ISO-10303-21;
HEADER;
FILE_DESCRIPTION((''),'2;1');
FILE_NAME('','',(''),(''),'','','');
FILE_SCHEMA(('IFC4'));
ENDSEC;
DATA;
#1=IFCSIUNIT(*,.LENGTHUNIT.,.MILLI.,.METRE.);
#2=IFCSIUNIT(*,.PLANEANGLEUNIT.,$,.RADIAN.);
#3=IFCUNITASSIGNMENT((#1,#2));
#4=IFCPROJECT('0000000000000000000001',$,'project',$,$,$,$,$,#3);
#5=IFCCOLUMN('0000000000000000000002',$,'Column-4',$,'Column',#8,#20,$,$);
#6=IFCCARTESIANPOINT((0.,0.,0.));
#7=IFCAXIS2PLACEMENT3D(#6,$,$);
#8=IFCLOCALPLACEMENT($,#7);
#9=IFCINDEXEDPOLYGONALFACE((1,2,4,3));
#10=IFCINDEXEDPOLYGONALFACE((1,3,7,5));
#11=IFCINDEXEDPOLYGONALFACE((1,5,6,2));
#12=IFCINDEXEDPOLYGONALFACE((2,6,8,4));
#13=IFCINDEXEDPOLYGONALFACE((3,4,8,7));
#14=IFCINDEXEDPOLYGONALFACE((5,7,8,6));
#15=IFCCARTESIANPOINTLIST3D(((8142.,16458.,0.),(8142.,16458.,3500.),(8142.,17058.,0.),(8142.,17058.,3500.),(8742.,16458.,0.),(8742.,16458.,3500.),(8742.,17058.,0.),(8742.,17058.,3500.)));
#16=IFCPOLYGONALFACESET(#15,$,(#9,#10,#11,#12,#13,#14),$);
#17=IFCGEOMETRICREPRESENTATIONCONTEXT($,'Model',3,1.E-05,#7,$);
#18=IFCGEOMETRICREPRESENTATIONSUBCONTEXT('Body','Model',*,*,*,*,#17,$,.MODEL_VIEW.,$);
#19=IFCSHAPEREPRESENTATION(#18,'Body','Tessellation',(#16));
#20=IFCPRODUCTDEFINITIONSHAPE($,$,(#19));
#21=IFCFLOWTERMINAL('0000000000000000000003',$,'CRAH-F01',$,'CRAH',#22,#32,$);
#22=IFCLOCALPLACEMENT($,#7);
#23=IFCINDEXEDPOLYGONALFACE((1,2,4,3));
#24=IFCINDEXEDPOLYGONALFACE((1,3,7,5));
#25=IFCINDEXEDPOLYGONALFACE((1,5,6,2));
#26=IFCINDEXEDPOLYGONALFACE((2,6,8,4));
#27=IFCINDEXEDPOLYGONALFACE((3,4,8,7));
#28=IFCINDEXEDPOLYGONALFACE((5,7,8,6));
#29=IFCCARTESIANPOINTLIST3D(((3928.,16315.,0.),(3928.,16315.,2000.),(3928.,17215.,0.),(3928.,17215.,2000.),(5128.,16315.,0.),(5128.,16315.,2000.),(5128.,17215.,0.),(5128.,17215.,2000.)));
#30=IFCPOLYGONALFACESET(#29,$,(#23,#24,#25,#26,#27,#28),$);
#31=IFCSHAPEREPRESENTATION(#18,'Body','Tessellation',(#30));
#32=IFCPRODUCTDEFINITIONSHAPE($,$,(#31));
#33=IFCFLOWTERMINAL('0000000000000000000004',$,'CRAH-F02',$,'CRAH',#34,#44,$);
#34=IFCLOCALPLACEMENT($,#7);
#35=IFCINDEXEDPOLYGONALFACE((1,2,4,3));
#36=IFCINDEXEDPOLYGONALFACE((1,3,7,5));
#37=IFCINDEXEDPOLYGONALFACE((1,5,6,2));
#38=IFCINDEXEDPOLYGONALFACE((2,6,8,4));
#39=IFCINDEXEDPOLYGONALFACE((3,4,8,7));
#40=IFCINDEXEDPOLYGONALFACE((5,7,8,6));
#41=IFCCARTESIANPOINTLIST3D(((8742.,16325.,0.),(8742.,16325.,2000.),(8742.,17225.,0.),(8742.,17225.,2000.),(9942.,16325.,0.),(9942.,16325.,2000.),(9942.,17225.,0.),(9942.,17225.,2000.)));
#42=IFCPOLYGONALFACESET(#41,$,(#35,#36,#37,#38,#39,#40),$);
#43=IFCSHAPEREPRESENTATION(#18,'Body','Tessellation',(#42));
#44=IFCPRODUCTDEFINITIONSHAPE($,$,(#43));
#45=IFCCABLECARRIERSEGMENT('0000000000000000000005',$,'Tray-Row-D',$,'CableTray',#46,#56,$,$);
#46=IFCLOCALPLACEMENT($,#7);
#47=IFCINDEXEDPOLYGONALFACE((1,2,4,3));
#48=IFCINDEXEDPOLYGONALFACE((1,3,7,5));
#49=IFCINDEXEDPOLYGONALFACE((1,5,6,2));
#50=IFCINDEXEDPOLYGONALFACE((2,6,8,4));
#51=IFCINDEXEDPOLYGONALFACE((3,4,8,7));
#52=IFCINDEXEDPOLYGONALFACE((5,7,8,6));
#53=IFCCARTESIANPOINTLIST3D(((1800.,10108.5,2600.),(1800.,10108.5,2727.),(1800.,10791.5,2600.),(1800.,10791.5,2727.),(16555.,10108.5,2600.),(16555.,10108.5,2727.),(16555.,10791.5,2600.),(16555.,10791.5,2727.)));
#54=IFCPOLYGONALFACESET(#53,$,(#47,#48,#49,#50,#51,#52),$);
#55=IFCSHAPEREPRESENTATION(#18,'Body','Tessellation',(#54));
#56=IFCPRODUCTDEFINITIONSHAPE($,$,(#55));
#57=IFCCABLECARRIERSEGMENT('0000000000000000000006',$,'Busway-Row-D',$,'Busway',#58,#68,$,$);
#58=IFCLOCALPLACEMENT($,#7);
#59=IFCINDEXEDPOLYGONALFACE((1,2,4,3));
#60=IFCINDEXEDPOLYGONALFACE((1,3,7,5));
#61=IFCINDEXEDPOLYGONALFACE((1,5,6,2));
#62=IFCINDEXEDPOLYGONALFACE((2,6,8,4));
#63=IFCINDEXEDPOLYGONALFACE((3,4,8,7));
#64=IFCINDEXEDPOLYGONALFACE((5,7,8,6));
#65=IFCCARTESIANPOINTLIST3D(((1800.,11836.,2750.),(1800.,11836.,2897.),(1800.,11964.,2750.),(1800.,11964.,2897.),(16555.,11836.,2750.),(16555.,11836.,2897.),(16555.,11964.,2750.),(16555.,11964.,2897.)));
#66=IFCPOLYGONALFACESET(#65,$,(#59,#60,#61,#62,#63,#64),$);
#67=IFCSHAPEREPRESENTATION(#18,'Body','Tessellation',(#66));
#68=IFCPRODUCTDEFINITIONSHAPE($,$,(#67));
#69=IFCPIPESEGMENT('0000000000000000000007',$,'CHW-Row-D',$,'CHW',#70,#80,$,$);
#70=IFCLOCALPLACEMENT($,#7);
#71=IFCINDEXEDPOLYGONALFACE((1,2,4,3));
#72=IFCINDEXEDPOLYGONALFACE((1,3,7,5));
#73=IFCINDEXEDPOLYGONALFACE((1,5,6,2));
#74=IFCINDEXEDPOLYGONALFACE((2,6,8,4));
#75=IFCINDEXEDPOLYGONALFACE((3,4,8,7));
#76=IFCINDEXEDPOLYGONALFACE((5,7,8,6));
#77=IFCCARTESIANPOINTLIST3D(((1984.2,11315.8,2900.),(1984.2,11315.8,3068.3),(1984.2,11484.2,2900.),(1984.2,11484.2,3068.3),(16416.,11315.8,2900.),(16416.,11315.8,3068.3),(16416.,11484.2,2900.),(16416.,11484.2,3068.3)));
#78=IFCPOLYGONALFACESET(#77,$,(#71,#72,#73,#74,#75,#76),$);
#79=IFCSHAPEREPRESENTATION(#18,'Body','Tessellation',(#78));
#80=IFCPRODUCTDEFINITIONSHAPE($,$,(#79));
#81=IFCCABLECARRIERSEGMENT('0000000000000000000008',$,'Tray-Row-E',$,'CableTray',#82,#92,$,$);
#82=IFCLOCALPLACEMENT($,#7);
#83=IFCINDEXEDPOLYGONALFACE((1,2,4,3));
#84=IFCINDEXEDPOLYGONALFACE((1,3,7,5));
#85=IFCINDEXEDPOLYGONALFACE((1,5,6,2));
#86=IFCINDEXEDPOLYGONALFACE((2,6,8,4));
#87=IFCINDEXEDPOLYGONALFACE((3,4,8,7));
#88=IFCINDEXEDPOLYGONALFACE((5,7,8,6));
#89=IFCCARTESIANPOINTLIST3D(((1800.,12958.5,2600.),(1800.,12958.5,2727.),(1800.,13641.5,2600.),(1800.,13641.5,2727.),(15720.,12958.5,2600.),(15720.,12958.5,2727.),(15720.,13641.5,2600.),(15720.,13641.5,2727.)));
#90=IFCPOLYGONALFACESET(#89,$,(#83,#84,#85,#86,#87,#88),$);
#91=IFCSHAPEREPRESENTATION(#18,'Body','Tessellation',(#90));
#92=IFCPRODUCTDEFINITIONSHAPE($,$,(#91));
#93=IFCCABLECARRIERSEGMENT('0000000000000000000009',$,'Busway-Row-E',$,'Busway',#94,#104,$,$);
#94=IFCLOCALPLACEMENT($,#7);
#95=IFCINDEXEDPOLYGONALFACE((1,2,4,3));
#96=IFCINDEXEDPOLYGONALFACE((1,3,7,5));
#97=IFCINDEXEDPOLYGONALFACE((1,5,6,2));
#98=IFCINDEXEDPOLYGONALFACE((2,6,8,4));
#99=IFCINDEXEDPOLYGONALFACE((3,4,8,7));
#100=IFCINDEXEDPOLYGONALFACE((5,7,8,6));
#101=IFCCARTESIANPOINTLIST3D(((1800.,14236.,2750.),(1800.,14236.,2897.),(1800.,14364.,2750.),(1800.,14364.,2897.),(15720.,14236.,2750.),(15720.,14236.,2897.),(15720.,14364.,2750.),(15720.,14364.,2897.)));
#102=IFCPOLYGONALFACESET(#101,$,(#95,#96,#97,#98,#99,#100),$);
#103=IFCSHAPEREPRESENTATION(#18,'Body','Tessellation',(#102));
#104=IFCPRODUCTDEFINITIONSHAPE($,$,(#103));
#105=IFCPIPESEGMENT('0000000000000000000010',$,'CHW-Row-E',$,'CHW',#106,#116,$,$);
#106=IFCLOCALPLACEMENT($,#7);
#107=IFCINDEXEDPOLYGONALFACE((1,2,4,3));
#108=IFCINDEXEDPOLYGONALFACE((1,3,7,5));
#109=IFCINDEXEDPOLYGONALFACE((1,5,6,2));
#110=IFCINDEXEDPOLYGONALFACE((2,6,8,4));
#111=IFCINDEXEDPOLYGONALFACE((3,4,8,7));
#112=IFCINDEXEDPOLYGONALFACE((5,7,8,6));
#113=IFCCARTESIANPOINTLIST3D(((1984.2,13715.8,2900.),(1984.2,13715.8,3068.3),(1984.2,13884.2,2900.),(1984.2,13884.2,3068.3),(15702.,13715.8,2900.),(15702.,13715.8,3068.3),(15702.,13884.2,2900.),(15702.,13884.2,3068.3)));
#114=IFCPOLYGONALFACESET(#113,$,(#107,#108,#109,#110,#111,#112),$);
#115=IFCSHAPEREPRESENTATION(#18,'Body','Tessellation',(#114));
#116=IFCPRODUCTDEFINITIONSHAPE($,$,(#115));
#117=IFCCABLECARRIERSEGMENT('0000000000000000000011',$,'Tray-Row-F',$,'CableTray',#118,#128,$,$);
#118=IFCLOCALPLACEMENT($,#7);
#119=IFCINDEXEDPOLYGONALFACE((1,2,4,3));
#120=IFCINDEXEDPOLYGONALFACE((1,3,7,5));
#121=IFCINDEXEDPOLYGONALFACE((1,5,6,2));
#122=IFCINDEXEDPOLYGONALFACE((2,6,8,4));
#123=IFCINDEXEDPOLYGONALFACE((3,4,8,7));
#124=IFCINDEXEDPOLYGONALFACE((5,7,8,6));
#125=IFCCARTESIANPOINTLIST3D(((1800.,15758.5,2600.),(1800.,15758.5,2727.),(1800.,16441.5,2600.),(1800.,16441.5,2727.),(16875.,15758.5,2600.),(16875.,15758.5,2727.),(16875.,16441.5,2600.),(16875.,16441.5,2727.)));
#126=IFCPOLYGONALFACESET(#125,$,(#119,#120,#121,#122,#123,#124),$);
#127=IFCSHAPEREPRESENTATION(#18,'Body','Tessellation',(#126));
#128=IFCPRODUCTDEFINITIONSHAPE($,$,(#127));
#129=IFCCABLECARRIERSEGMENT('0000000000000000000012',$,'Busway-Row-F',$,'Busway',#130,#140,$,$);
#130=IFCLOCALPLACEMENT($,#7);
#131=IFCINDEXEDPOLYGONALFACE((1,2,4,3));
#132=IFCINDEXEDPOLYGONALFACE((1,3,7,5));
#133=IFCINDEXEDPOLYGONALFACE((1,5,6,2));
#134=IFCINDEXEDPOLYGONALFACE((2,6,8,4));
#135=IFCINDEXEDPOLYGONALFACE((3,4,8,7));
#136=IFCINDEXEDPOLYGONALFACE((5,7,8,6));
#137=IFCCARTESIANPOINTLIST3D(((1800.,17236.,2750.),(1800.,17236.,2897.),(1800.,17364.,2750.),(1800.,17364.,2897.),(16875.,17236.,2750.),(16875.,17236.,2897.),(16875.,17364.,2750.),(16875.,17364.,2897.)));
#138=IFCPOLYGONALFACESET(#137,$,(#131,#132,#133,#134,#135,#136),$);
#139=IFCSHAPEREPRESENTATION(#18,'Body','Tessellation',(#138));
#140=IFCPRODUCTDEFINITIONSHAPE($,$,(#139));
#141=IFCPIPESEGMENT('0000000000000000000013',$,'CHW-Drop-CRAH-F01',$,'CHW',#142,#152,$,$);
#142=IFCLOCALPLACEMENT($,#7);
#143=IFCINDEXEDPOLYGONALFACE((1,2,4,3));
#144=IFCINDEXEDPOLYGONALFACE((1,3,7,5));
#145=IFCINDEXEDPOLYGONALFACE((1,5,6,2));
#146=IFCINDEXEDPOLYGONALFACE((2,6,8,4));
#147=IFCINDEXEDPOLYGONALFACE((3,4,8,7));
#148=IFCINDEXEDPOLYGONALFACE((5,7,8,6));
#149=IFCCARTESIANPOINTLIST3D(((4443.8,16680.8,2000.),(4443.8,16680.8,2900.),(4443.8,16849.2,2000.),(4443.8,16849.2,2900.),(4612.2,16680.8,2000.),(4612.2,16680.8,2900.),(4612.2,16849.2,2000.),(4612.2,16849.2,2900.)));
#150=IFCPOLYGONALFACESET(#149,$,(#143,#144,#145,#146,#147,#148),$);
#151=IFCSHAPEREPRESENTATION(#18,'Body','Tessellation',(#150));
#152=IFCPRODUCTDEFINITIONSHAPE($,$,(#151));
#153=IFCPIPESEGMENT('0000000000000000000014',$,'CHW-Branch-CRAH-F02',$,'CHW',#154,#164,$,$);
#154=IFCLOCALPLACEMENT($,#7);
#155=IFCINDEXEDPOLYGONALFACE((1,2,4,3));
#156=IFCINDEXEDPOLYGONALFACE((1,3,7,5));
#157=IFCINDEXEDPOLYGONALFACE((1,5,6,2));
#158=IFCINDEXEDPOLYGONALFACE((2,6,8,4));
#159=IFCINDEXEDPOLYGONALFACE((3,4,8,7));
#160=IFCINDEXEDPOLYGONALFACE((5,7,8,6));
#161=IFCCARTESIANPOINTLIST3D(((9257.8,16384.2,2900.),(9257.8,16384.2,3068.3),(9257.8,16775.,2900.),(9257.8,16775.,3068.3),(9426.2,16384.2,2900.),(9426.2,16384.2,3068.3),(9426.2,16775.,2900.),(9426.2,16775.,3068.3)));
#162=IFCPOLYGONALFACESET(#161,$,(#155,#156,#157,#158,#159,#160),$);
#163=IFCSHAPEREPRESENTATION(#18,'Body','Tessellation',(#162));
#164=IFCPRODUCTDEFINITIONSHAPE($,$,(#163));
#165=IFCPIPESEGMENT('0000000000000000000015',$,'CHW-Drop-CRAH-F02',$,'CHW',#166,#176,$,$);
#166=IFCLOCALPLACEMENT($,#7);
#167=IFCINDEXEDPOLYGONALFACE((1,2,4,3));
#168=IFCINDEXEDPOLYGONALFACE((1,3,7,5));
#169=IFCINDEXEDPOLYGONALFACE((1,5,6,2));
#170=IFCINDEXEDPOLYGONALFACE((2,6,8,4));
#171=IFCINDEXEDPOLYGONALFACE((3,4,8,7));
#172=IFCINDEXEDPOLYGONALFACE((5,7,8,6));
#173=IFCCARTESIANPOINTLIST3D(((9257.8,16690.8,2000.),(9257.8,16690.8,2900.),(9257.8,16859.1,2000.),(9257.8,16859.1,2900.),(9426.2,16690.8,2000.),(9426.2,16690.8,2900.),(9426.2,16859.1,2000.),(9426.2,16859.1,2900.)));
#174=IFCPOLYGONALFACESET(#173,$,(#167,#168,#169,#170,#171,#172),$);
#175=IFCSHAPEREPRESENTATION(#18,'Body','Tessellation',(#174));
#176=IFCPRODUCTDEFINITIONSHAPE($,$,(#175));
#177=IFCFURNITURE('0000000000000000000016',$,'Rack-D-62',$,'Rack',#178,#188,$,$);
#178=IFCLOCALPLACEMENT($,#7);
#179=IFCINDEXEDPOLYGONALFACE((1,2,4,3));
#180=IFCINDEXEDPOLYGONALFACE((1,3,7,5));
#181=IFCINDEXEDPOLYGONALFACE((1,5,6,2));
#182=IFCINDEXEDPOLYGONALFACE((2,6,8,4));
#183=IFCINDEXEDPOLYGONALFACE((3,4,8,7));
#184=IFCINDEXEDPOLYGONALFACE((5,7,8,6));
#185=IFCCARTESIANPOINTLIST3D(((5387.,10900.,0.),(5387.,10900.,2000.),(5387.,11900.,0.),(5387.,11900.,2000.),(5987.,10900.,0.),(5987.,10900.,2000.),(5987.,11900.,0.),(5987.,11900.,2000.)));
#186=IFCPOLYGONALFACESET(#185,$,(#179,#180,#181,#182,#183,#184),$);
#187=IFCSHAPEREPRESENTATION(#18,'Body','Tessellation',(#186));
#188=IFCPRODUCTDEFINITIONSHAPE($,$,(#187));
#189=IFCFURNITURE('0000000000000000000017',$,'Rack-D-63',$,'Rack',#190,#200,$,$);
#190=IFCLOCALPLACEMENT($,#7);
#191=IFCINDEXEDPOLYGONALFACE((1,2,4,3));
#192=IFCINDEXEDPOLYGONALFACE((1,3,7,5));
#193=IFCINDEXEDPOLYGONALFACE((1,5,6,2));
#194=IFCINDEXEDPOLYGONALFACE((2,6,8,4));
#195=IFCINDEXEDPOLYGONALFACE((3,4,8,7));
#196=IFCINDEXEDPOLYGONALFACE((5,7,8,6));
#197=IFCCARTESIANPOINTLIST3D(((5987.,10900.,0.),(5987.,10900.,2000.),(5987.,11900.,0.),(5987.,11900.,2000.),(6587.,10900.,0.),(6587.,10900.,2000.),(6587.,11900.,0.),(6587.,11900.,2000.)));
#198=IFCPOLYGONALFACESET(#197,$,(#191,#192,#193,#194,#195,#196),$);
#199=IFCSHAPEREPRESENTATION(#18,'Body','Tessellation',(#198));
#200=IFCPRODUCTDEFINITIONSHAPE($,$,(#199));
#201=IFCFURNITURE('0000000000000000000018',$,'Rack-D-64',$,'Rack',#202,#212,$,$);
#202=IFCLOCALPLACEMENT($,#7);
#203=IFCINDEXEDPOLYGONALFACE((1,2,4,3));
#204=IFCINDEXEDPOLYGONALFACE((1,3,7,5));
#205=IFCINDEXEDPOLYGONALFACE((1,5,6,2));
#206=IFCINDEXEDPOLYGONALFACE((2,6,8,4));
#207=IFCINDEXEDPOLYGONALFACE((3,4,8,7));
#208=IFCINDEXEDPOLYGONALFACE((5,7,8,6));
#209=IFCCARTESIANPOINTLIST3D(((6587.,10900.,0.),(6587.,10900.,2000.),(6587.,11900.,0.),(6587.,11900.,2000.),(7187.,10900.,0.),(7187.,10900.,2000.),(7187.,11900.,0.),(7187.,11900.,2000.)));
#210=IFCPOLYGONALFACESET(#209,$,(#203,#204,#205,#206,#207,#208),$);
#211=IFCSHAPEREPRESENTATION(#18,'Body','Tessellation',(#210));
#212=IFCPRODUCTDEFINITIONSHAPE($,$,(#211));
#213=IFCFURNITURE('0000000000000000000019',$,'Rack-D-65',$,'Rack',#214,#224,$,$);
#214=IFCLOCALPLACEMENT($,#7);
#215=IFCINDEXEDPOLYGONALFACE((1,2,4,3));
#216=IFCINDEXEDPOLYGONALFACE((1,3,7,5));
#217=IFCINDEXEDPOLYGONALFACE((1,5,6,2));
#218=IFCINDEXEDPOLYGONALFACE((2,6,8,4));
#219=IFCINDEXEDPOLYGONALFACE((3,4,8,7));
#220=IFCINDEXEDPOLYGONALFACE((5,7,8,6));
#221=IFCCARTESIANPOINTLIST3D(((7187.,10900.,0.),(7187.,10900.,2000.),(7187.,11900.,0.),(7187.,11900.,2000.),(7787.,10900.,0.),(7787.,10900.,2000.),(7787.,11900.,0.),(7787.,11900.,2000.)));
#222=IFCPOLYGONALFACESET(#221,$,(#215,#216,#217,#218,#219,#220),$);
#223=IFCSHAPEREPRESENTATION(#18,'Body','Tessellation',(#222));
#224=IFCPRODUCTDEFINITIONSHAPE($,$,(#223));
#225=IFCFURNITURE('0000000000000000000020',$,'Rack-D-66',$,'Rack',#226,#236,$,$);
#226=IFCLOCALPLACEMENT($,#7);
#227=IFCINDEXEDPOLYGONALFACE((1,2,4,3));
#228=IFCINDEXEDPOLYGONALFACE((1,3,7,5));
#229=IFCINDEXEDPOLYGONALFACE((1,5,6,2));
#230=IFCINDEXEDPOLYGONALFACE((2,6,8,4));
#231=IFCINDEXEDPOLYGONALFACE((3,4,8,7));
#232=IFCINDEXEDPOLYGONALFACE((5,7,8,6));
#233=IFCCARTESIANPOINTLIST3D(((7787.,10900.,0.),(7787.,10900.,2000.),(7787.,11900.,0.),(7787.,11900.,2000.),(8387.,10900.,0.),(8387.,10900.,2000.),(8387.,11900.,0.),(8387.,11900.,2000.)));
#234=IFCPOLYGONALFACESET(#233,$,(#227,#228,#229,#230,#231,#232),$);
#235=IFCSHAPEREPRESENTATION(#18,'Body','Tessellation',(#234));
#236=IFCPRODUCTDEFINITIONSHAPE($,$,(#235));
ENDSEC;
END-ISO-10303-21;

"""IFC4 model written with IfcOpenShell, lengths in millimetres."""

from ifc_helpers import new_model, si_unit, frame, origin, place, context, subcontext, project, rectangle, extrude, element, save


model = new_model("IFC4")

# Units and contexts
model_context = context("Model", 3, precision=1e-05, world=origin())
body_context = subcontext(model_context, "Body", "Model", "MODEL_VIEW")
ifc_project = project(units=[si_unit("LENGTHUNIT", "METRE", prefix="MILLI"), si_unit("PLANEANGLEUNIT", "RADIAN")])

# Column
column_placement = place(None, frame((8442.0, 16758.0, 0.0)))
element("IfcColumn", 1, at=column_placement, Name="Column-4", ObjectType="Column", context=body_context, shape_type="SweptSolid", body=[
    extrude(rectangle(XDim=600.0, YDim=600.0), None, (0.0, 0.0, 1.0), 3500.0),
])

# Flow terminals
for number, where, name in (
    (2, (4528.0, 16765.0, 0.0), "CRAH-F01"),
    (3, (9342.0, 16775.0, 0.0), "CRAH-F02"),
):
    element("IfcFlowTerminal", number, at=place(None, frame(where)), Name=name, ObjectType="CRAH", context=body_context, shape_type="SweptSolid", body=[
        extrude(rectangle(XDim=1200.0, YDim=900.0), None, (0.0, 0.0, 1.0), 2000.0),
    ])

# Cable carrier segments
cable_carrier_segment_1_placement = place(None, frame((9177.5, 10450.0, 2600.0)))
element("IfcCableCarrierSegment", 4, at=cable_carrier_segment_1_placement, Name="Tray-Row-D", ObjectType="CableTray", context=body_context, shape_type="SweptSolid", body=[
    extrude(rectangle(XDim=14755.0, YDim=683.0), None, (0.0, 0.0, 1.0), 127.0),
])
cable_carrier_segment_2_placement = place(None, frame((9177.5, 11900.0, 2750.0)))
element("IfcCableCarrierSegment", 5, at=cable_carrier_segment_2_placement, Name="Busway-Row-D", ObjectType="Busway", context=body_context, shape_type="SweptSolid", body=[
    extrude(rectangle(XDim=14755.0, YDim=128.0), None, (0.0, 0.0, 1.0), 147.0),
])

# Pipe segment
pipe_segment_1_placement = place(None, frame((9200.1, 11400.0, 2900.0)))
element("IfcPipeSegment", 6, at=pipe_segment_1_placement, Name="CHW-Row-D", ObjectType="CHW", context=body_context, shape_type="SweptSolid", body=[
    extrude(rectangle(XDim=14431.9, YDim=168.3), None, (0.0, 0.0, 1.0), 168.3),
])

# Cable carrier segments
cable_carrier_segment_3_placement = place(None, frame((8760.0, 13300.0, 2600.0)))
element("IfcCableCarrierSegment", 7, at=cable_carrier_segment_3_placement, Name="Tray-Row-E", ObjectType="CableTray", context=body_context, shape_type="SweptSolid", body=[
    extrude(rectangle(XDim=13920.0, YDim=683.0), None, (0.0, 0.0, 1.0), 127.0),
])
cable_carrier_segment_4_placement = place(None, frame((8760.0, 14300.0, 2750.0)))
element("IfcCableCarrierSegment", 8, at=cable_carrier_segment_4_placement, Name="Busway-Row-E", ObjectType="Busway", context=body_context, shape_type="SweptSolid", body=[
    extrude(rectangle(XDim=13920.0, YDim=128.0), None, (0.0, 0.0, 1.0), 147.0),
])

# Pipe segment
pipe_segment_2_placement = place(None, frame((8843.1, 13800.0, 2900.0)))
element("IfcPipeSegment", 9, at=pipe_segment_2_placement, Name="CHW-Row-E", ObjectType="CHW", context=body_context, shape_type="SweptSolid", body=[
    extrude(rectangle(XDim=13717.9, YDim=168.3), None, (0.0, 0.0, 1.0), 168.3),
])

# Cable carrier segments
cable_carrier_segment_5_placement = place(None, frame((9337.5, 16100.0, 2600.0)))
element("IfcCableCarrierSegment", 10, at=cable_carrier_segment_5_placement, Name="Tray-Row-F", ObjectType="CableTray", context=body_context, shape_type="SweptSolid", body=[
    extrude(rectangle(XDim=15075.0, YDim=683.0), None, (0.0, 0.0, 1.0), 127.0),
])
cable_carrier_segment_6_placement = place(None, frame((9337.5, 17300.0, 2750.0)))
element("IfcCableCarrierSegment", 11, at=cable_carrier_segment_6_placement, Name="Busway-Row-F", ObjectType="Busway", context=body_context, shape_type="SweptSolid", body=[
    extrude(rectangle(XDim=15075.0, YDim=128.0), None, (0.0, 0.0, 1.0), 147.0),
])

# Pipe segments
pipe_segment_3_placement = place(None, frame((4528.0, 16765.0, 2000.0)))
element("IfcPipeSegment", 12, at=pipe_segment_3_placement, Name="CHW-Drop-CRAH-F01", ObjectType="CHW", context=body_context, shape_type="SweptSolid", body=[
    extrude(rectangle(XDim=168.3, YDim=168.3), None, (0.0, 0.0, 1.0), 900.0),
])
pipe_segment_4_placement = place(None, frame((9342.0, 16579.6, 2900.0)))
element("IfcPipeSegment", 13, at=pipe_segment_4_placement, Name="CHW-Branch-CRAH-F02", ObjectType="CHW", context=body_context, shape_type="SweptSolid", body=[
    extrude(rectangle(XDim=168.3, YDim=390.8), None, (0.0, 0.0, 1.0), 168.3),
])
pipe_segment_5_placement = place(None, frame((9342.0, 16775.0, 2000.0)))
element("IfcPipeSegment", 14, at=pipe_segment_5_placement, Name="CHW-Drop-CRAH-F02", ObjectType="CHW", context=body_context, shape_type="SweptSolid", body=[
    extrude(rectangle(XDim=168.3, YDim=168.3), None, (0.0, 0.0, 1.0), 900.0),
])

# Furniture
for number, where, name in (
    (15, (5687.0, 11400.0, 0.0), "Rack-D-62"),
    (16, (6287.0, 11400.0, 0.0), "Rack-D-63"),
    (17, (6887.0, 11400.0, 0.0), "Rack-D-64"),
    (18, (7487.0, 11400.0, 0.0), "Rack-D-65"),
    (19, (8087.0, 11400.0, 0.0), "Rack-D-66"),
):
    element("IfcFurniture", number, at=place(None, frame(where)), Name=name, ObjectType="Rack", context=body_context, shape_type="SweptSolid", body=[
        extrude(rectangle(XDim=600.0, YDim=1000.0), None, (0.0, 0.0, 1.0), 2000.0),
    ])

save(model, "model.ifc")
